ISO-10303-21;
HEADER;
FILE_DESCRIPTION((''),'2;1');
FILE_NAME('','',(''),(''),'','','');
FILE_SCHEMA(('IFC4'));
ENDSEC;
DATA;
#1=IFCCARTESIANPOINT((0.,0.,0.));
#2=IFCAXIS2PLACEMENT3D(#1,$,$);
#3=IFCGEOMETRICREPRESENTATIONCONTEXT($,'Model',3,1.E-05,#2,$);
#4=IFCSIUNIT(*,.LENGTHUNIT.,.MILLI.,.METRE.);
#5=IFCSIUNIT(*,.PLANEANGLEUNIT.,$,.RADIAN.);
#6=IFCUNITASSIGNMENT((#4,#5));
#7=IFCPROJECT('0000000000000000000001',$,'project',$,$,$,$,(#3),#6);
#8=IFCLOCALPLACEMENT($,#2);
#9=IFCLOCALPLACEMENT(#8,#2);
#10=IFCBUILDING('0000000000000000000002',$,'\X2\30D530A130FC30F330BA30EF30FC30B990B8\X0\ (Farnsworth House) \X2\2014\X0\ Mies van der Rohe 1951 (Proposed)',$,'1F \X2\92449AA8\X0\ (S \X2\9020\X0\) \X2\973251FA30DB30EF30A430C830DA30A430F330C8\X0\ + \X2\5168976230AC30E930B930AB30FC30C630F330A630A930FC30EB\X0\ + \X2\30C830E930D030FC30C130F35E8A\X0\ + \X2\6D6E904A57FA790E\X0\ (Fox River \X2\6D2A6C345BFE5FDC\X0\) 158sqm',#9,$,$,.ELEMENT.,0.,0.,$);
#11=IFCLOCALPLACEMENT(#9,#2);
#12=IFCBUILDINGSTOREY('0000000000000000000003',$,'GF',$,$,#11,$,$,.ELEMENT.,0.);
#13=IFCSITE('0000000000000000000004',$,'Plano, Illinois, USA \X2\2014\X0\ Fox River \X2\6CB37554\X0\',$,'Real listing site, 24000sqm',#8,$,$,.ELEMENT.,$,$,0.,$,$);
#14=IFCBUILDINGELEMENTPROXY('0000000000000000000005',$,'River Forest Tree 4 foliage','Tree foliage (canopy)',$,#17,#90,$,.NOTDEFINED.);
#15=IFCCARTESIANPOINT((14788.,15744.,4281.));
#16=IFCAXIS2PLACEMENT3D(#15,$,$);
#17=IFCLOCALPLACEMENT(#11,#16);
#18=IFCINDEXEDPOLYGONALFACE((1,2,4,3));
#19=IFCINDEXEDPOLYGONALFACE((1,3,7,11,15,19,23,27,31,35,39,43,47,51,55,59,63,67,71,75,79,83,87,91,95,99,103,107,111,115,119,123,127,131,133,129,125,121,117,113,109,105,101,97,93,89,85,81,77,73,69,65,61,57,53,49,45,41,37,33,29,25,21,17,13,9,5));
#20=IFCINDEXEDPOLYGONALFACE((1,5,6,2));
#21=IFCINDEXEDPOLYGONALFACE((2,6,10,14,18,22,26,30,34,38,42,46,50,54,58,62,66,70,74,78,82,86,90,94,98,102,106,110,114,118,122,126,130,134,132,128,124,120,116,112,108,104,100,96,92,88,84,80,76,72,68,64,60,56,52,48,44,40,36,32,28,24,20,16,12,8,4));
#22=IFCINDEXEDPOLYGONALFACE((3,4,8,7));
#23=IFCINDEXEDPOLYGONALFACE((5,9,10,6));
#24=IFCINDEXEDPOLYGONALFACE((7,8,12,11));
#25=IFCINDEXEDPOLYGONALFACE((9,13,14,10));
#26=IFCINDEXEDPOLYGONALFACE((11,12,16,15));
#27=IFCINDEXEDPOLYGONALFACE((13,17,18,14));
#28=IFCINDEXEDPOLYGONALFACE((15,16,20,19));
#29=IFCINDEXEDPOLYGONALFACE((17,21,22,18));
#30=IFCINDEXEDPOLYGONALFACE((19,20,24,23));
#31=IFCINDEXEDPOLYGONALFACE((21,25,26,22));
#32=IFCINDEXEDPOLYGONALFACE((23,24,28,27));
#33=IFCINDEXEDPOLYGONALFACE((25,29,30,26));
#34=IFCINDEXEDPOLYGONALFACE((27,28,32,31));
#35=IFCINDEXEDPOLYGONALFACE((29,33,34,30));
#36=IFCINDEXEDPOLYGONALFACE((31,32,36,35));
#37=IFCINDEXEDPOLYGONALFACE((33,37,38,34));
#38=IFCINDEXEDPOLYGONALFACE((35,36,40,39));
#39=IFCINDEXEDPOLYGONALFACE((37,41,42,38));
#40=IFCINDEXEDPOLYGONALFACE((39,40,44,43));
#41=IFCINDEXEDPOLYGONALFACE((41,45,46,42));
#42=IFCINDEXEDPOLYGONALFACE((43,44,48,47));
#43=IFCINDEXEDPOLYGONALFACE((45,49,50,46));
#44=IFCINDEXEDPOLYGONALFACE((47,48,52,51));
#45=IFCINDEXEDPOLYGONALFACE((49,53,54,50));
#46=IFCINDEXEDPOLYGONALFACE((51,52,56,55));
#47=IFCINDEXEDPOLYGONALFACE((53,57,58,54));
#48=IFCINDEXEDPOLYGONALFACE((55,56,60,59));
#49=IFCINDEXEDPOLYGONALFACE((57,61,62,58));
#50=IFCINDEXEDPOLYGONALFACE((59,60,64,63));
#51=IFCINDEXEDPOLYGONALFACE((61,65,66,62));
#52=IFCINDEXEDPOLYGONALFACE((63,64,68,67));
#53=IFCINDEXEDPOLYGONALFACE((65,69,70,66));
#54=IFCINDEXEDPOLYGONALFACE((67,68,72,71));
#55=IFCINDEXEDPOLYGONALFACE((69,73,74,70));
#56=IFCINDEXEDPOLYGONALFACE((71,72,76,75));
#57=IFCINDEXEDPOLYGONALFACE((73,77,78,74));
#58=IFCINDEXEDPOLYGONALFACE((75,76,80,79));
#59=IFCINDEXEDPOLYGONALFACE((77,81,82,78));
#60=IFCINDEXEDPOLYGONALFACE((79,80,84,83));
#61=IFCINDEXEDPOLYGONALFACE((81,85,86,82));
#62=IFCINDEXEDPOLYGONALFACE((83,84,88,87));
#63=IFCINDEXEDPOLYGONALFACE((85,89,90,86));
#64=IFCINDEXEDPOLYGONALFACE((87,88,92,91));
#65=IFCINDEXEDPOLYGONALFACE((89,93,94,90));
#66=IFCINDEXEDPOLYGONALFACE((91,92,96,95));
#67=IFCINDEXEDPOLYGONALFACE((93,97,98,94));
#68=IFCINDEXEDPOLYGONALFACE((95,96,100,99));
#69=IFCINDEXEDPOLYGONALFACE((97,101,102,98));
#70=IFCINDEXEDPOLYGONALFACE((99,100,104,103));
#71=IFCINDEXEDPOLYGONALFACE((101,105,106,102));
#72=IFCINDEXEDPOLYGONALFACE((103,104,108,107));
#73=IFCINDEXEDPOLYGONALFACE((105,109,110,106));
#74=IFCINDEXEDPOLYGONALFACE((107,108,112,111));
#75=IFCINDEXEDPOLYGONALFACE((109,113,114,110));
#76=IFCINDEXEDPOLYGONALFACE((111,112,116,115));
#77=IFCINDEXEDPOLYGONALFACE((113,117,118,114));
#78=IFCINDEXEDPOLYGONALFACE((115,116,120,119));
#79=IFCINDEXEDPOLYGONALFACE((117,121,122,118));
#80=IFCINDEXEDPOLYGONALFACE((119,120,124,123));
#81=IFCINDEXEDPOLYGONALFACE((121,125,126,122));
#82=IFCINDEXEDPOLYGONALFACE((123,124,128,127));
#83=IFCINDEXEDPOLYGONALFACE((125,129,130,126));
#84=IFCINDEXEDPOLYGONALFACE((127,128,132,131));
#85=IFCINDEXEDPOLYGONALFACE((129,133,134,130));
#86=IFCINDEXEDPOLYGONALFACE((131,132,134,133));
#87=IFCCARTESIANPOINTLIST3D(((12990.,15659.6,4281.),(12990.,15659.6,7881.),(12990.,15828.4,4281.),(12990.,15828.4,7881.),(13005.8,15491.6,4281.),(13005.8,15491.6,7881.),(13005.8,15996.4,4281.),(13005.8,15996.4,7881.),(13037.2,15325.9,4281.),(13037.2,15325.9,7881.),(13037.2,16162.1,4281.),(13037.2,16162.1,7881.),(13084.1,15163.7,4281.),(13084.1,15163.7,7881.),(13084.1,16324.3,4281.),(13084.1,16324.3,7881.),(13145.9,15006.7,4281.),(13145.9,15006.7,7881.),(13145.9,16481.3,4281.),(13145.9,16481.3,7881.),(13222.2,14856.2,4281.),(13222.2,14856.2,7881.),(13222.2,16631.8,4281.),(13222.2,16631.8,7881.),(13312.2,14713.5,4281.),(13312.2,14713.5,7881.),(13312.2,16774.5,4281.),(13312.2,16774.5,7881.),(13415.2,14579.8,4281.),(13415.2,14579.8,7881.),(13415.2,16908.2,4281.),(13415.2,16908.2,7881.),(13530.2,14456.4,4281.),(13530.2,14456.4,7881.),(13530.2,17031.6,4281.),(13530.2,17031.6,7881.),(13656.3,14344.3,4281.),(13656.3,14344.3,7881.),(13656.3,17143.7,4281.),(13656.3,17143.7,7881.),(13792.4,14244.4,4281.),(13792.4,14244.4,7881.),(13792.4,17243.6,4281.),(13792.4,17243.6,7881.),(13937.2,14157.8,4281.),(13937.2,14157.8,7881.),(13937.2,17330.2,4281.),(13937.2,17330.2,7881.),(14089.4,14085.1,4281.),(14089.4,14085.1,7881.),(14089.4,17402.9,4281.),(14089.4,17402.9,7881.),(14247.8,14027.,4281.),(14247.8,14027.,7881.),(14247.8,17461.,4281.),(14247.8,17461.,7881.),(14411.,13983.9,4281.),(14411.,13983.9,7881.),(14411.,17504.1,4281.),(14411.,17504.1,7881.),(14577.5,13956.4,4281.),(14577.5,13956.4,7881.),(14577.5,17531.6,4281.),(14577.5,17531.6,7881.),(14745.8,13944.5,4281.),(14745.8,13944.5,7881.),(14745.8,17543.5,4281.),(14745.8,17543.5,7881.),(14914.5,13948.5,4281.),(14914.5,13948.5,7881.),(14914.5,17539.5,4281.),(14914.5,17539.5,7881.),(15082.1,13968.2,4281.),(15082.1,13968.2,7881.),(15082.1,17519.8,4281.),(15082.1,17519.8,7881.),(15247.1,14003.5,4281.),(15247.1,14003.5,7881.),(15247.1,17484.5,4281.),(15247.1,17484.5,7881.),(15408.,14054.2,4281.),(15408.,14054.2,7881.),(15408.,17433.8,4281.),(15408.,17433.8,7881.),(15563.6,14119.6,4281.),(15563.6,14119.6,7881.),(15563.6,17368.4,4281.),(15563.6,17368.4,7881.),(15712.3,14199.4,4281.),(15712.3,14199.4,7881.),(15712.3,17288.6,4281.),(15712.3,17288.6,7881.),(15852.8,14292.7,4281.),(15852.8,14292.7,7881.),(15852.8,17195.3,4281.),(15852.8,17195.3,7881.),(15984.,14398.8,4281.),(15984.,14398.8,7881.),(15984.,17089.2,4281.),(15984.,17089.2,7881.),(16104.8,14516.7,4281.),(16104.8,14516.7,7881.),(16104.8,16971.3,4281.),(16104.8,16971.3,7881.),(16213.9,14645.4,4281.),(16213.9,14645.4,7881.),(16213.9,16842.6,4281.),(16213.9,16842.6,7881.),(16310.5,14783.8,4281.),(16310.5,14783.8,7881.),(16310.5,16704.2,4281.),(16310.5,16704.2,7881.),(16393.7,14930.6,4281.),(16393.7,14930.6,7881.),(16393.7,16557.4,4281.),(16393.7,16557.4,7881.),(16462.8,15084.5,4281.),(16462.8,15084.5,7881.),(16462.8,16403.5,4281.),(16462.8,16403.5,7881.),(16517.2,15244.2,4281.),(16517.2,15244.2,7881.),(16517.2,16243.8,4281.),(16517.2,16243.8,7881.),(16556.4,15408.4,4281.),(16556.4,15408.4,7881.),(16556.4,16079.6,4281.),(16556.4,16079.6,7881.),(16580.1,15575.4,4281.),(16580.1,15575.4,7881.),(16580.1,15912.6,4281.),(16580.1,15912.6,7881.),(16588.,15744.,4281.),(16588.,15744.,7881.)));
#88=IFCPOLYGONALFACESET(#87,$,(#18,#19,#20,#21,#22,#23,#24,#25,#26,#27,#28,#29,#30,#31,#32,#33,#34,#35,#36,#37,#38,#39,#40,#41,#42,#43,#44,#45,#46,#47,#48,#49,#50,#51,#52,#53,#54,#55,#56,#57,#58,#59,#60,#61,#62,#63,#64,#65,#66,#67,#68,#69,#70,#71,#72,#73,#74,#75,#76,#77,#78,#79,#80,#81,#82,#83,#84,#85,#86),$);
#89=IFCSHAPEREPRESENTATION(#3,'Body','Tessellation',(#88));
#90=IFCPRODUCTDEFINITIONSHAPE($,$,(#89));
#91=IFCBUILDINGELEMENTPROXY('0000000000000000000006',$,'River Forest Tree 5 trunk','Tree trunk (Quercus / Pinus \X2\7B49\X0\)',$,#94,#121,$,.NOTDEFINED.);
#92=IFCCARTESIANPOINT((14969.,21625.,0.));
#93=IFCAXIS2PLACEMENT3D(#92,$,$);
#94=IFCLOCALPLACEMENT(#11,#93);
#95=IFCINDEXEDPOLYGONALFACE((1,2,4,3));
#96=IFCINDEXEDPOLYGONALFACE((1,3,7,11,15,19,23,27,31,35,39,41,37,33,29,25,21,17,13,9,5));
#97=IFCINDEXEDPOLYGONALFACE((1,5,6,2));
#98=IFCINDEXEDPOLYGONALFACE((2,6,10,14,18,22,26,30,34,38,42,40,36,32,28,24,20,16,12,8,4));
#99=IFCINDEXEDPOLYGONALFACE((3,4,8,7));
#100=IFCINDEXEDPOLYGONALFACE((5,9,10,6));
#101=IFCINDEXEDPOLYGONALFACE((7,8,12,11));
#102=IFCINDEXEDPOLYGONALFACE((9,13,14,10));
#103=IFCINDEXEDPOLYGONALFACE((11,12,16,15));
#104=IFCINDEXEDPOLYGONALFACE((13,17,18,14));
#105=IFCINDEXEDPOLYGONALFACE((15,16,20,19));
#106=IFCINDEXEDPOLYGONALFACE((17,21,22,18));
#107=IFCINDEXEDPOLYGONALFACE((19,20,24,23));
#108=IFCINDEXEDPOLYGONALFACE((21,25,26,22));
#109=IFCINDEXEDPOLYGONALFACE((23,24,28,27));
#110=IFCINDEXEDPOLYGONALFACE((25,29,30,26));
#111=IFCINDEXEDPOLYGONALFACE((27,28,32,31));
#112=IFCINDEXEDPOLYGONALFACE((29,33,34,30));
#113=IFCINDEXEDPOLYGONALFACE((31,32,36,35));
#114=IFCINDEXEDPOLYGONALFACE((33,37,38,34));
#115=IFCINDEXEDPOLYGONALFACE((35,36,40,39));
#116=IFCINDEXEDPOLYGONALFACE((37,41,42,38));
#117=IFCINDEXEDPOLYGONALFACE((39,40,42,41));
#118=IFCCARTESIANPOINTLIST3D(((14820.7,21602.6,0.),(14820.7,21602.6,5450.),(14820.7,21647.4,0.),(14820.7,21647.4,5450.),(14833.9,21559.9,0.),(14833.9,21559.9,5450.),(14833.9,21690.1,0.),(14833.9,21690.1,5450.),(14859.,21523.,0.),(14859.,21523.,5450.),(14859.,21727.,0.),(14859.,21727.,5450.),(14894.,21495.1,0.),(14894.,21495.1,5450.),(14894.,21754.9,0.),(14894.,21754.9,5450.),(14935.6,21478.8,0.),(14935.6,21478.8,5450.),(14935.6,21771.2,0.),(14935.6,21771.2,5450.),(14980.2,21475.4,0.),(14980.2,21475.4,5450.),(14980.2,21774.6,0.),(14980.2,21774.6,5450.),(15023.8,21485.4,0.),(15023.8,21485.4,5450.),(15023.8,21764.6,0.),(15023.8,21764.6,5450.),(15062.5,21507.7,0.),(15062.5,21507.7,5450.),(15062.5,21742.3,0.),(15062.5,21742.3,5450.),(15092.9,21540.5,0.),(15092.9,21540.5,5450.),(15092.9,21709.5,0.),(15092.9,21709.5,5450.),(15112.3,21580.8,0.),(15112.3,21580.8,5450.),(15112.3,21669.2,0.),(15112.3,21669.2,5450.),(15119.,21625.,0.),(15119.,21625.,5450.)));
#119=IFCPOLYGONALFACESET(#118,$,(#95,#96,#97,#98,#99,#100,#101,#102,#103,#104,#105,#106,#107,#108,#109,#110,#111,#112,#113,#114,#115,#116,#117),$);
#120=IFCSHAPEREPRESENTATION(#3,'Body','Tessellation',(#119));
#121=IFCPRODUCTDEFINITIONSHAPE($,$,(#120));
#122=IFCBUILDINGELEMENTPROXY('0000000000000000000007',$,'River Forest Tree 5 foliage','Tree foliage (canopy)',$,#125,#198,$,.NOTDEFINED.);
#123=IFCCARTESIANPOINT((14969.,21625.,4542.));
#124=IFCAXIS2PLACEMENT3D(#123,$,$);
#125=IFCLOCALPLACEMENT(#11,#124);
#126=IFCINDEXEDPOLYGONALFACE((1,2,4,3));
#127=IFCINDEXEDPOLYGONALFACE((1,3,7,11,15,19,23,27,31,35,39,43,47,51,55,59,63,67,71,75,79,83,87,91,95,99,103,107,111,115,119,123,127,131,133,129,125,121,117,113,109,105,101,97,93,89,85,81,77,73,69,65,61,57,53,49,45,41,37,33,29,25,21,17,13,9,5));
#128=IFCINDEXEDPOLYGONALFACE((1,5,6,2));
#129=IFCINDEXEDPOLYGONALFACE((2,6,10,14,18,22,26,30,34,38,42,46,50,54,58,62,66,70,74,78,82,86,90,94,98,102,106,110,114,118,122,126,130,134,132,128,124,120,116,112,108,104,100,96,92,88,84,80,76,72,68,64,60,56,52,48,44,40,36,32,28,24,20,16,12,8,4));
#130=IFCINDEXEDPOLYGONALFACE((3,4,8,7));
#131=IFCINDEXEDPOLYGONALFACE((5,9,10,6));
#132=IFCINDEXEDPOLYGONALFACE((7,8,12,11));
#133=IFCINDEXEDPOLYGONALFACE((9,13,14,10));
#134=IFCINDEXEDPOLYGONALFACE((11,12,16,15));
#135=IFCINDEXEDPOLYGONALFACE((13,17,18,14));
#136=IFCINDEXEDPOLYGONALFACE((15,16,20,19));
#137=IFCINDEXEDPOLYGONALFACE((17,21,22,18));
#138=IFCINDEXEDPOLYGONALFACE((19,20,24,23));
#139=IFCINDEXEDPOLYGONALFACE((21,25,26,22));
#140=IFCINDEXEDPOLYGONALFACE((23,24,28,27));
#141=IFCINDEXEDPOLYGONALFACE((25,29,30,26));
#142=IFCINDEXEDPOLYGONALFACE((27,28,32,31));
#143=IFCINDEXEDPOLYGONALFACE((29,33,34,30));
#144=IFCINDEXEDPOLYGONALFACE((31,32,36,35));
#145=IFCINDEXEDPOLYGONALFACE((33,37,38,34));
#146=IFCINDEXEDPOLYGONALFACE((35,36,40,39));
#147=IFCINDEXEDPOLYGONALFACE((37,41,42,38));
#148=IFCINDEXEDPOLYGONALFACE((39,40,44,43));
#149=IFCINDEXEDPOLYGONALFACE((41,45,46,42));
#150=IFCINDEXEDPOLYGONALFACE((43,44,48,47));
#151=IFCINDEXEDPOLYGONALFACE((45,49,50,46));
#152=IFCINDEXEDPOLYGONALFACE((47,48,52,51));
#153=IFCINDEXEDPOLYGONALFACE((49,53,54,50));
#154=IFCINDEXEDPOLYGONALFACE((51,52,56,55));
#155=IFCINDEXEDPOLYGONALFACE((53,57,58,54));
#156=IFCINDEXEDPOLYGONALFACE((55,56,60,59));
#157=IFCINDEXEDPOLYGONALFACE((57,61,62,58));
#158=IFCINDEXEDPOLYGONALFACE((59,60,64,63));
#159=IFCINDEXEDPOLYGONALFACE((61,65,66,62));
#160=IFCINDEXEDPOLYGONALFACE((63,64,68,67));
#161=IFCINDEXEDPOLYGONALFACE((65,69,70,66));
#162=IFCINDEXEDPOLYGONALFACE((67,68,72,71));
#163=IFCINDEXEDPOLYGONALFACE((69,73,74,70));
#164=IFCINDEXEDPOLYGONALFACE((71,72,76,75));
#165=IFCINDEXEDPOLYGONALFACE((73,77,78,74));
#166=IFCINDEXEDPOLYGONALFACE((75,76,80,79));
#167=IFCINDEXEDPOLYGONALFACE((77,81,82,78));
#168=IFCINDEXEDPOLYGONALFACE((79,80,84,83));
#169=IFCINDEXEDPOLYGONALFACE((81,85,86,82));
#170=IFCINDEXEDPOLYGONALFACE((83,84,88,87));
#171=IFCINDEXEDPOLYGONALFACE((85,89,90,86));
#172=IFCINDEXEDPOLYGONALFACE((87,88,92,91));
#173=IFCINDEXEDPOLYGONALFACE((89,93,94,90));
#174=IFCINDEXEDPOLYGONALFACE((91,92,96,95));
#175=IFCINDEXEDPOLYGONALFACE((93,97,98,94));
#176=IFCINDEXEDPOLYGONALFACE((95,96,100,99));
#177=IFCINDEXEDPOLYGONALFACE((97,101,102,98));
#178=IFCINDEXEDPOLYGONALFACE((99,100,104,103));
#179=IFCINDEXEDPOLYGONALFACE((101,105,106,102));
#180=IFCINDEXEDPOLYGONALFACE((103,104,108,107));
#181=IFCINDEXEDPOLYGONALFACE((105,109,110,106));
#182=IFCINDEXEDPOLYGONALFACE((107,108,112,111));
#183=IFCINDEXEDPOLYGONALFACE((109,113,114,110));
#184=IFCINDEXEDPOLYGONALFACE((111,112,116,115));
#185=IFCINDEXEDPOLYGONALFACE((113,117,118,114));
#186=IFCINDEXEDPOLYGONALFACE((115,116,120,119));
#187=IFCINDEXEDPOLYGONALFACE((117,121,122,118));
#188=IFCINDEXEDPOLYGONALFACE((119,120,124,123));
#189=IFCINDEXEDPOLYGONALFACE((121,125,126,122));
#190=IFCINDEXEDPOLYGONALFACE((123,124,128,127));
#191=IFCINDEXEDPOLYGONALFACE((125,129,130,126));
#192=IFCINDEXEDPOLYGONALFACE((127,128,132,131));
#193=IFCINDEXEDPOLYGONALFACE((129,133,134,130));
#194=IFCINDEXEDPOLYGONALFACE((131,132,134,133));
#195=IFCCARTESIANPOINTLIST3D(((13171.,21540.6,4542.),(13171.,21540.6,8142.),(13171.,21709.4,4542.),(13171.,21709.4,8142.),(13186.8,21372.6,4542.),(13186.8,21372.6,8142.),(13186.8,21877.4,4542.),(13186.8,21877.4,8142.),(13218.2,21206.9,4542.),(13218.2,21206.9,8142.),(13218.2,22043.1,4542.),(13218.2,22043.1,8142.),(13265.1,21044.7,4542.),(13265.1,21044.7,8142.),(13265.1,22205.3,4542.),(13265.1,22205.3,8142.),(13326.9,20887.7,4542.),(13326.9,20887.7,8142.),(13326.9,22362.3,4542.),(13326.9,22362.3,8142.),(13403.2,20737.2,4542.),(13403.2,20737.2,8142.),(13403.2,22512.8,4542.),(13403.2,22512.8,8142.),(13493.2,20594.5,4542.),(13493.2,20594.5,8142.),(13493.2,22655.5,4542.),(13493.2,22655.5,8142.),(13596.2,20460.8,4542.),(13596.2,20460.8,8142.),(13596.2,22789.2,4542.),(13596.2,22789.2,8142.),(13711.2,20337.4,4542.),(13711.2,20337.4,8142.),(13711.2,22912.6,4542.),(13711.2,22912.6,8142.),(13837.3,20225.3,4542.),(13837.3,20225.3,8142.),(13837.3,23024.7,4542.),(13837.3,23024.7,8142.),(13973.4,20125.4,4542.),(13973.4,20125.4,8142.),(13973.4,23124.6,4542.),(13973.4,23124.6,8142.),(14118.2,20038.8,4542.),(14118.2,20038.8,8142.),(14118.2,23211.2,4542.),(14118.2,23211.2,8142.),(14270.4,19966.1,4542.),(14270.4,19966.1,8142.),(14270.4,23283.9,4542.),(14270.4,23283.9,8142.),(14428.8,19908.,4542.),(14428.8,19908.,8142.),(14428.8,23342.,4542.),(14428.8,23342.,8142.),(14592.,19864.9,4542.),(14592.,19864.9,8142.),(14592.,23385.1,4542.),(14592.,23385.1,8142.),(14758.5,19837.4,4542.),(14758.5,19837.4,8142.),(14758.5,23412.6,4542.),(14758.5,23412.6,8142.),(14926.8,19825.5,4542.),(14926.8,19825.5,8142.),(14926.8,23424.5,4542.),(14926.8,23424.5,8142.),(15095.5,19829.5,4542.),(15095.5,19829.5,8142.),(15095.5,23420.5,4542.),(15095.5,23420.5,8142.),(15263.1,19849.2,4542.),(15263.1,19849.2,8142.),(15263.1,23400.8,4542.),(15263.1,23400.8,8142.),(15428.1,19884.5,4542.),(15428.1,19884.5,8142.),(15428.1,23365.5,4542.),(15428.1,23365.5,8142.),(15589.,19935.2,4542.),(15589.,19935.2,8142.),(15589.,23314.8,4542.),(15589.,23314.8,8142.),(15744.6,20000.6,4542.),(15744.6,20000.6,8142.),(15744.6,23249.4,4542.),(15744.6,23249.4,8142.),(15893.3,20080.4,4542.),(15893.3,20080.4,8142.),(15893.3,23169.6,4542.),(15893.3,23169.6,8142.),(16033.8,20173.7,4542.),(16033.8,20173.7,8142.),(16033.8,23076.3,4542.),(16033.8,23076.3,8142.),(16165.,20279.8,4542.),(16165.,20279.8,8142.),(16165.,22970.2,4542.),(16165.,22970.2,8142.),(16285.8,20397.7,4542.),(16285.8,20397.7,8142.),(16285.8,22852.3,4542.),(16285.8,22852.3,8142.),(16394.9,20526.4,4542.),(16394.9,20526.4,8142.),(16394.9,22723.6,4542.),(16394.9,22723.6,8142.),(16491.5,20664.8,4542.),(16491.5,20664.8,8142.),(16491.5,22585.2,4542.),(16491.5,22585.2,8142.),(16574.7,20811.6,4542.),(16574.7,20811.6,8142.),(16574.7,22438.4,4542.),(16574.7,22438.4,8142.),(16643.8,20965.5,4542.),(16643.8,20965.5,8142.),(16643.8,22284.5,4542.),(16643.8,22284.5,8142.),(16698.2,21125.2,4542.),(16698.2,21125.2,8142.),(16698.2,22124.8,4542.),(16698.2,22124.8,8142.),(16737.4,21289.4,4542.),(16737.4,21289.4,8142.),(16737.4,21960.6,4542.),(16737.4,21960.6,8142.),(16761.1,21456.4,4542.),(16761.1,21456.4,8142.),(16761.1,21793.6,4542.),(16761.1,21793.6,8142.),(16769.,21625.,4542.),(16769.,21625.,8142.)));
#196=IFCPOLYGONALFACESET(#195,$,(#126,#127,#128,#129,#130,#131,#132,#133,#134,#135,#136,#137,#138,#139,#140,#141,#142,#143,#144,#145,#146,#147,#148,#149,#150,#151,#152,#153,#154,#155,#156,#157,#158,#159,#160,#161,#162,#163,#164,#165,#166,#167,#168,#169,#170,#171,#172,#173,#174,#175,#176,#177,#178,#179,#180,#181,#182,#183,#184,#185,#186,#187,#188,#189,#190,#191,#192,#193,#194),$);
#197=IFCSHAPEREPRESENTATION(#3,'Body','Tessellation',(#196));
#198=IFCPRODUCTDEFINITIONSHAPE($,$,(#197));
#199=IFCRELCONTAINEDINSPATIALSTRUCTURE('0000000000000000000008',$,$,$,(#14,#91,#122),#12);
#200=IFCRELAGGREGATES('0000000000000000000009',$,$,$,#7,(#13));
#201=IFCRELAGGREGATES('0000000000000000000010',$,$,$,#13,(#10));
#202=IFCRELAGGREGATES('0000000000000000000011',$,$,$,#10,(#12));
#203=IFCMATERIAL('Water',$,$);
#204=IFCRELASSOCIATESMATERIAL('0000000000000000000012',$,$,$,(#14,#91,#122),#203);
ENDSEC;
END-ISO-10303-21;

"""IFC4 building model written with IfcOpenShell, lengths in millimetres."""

from ifc_helpers import new_model, si_unit, frame, origin, origin_2d, place, context, project, spatial, circle, extrude, material, element, save


model = new_model("IFC4")

# Units and contexts
model_context = context("Model", 3, precision=1e-05, world=origin())
ifc_project = project(units=[si_unit("LENGTHUNIT", "METRE", prefix="MILLI"), si_unit("PLANEANGLEUNIT", "RADIAN")], contexts=[model_context])

# Site, building, storey
site_placement = place(None, origin())
site = spatial("IfcSite", under=ifc_project, at=site_placement, Name="Plano, Illinois, USA — Fox River 河畔", ObjectType="Real listing site, 24000sqm", CompositionType="ELEMENT", RefElevation=0.0)
building_placement = place(site_placement, origin())
building = spatial("IfcBuilding", under=site, at=building_placement, Name="ファーンズワース邸 (Farnsworth House) — Mies van der Rohe 1951 (Proposed)", ObjectType="1F 鉄骨 (S 造) 露出ホワイトペイント + 全面ガラスカーテンウォール + トラバーチン床 + 浮遊基礎 (Fox River 洪水対応) 158sqm", CompositionType="ELEMENT", ElevationOfRefHeight=0.0, ElevationOfTerrain=0.0)
storey_placement = place(building_placement, origin())
storey = spatial("IfcBuildingStorey", under=building, at=storey_placement, Name="GF", CompositionType="ELEMENT", Elevation=0.0)

# Building element proxies
ifc_material_1 = material(Name="Water")
proxy_1_placement = place(storey_placement, frame((14788.0, 15744.0, 4281.0)))
element("IfcBuildingElementProxy", 1, at=proxy_1_placement, inside=storey, material=ifc_material_1, Name="River Forest Tree 4 foliage", Description="Tree foliage (canopy)", PredefinedType="NOTDEFINED", context=model_context, shape_type="SweptSolid", body=[
    extrude(circle(Radius=1800.0, at=origin_2d()), frame((14788.0, 15744.0, 4281.0)), (0.0, 0.0, 1.0), 3600.0),
])
proxy_2_placement = place(storey_placement, frame((14969.0, 21625.0, 0.0)))
element("IfcBuildingElementProxy", 2, at=proxy_2_placement, inside=storey, material=ifc_material_1, Name="River Forest Tree 5 trunk", Description="Tree trunk (Quercus / Pinus 等)", PredefinedType="NOTDEFINED", context=model_context, shape_type="SweptSolid", body=[
    extrude(circle(Radius=150.0, at=origin_2d()), frame((14969.0, 21625.0, 0.0)), (0.0, 0.0, 1.0), 5450.0),
])
proxy_3_placement = place(storey_placement, frame((14969.0, 21625.0, 4542.0)))
element("IfcBuildingElementProxy", 3, at=proxy_3_placement, inside=storey, material=ifc_material_1, Name="River Forest Tree 5 foliage", Description="Tree foliage (canopy)", PredefinedType="NOTDEFINED", context=model_context, shape_type="SweptSolid", body=[
    extrude(circle(Radius=1800.0, at=origin_2d()), frame((14969.0, 21625.0, 4542.0)), (0.0, 0.0, 1.0), 3600.0),
])

save(model, "model.ifc")
